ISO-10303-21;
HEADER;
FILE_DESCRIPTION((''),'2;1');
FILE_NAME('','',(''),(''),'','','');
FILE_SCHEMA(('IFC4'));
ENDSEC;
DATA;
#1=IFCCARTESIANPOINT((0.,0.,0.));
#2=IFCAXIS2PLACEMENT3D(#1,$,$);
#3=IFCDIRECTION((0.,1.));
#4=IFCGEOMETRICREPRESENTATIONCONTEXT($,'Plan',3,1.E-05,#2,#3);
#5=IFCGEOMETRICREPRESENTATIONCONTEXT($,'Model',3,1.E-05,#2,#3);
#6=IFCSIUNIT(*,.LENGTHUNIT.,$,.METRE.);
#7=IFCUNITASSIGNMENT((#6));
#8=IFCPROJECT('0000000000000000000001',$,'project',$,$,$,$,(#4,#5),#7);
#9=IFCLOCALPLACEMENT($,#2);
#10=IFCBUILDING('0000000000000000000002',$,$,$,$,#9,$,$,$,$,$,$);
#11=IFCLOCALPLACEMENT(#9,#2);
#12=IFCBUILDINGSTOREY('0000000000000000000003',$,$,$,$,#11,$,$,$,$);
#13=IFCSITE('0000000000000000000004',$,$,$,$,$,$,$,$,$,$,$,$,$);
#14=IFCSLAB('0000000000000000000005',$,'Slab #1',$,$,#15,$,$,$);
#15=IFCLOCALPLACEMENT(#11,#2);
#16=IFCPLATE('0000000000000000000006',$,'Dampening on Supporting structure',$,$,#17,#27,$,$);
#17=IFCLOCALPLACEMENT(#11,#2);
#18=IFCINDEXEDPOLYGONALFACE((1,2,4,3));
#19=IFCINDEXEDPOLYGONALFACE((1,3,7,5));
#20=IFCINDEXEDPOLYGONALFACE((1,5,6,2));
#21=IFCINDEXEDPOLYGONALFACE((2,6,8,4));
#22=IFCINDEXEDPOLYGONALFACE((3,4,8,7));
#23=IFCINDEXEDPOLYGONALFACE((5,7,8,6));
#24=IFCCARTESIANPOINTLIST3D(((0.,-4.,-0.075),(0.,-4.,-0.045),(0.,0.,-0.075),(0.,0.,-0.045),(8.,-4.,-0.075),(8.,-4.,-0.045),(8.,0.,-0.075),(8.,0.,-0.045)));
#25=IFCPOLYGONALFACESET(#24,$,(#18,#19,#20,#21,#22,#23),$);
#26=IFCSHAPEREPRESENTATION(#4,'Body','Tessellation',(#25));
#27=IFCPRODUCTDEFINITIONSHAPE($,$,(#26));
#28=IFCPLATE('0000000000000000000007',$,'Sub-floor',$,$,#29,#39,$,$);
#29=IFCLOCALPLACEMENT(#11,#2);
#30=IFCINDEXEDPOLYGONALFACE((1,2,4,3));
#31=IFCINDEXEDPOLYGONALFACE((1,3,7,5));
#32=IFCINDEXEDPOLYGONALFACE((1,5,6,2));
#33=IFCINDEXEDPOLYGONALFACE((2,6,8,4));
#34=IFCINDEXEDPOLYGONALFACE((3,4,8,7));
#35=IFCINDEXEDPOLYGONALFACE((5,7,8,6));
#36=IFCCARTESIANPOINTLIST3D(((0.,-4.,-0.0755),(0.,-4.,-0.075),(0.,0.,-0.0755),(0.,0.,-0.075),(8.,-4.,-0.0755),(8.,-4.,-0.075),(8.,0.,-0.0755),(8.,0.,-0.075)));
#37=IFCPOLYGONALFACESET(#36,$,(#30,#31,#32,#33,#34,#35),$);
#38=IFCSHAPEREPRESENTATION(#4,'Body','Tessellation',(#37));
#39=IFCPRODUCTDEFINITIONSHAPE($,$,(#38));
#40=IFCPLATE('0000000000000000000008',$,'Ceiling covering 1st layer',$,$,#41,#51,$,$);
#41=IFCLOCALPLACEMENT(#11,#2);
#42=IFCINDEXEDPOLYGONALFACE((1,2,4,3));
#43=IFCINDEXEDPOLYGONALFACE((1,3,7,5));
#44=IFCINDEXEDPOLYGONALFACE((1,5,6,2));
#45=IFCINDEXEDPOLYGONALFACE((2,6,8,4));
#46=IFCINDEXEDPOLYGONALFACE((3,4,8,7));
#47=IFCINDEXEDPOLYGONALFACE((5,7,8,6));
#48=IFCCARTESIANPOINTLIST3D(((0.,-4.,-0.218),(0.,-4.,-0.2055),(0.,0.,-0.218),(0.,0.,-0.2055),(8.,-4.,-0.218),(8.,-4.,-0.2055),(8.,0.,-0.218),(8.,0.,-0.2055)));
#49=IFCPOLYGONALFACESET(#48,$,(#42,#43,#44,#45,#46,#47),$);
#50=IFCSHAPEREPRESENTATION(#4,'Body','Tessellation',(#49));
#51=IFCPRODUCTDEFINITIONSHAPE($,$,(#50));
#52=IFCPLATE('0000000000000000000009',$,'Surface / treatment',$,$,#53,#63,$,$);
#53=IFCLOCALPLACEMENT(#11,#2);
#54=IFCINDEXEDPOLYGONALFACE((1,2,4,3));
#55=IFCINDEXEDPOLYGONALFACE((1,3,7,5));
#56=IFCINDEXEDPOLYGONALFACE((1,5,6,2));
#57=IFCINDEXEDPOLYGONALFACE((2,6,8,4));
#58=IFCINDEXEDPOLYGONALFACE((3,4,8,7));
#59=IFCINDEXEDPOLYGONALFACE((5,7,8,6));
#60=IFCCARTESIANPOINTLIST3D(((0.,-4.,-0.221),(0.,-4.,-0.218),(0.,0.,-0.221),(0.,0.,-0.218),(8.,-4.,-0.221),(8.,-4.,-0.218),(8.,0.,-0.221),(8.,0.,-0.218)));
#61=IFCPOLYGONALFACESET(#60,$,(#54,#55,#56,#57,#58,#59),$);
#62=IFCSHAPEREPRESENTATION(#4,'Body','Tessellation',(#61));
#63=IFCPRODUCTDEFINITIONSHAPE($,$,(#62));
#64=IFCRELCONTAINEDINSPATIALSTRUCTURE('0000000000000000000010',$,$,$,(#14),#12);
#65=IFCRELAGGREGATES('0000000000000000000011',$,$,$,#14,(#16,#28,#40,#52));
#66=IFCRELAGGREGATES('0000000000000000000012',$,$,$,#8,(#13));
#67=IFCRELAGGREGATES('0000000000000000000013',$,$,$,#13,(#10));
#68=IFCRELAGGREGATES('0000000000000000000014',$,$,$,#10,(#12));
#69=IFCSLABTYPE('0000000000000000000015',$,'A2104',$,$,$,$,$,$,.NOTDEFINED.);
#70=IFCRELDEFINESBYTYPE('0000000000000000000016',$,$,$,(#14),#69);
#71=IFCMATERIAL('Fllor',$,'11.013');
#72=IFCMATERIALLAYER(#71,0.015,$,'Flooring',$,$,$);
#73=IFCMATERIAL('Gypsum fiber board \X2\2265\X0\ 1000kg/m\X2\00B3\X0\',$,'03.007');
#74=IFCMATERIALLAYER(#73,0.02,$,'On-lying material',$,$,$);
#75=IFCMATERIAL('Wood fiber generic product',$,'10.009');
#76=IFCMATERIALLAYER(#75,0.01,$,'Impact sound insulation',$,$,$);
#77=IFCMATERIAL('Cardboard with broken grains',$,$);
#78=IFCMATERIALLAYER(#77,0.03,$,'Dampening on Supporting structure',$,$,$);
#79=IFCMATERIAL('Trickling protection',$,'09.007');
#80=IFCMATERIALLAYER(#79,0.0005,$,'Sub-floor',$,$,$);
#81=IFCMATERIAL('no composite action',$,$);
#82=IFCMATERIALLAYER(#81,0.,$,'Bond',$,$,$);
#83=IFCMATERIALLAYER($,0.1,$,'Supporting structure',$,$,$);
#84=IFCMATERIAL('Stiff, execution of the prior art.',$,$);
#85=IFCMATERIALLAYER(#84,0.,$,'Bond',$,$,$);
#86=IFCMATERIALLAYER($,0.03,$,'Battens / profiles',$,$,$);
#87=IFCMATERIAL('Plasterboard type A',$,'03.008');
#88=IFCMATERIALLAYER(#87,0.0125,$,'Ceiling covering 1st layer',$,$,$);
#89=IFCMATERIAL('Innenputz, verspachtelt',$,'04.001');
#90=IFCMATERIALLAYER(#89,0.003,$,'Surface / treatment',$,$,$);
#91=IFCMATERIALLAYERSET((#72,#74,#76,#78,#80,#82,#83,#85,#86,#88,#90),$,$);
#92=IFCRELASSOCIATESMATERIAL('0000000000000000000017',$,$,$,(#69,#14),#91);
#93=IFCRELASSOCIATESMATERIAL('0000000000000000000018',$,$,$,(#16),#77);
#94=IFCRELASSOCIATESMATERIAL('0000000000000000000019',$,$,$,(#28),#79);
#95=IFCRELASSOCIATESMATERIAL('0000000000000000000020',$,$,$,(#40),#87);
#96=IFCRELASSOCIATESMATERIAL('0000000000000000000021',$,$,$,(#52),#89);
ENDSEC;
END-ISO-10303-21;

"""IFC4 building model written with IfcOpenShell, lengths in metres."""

from ifc_helpers import new_model, si_unit, direction, frame, frame_2d, origin, place, context, project, spatial, rectangle, extrude, material, layer, layer_set, type_object, element, aggregate, save


model = new_model("IFC4")

# Units and contexts
plan_context = context("Plan", 3, precision=1e-05, world=origin(), true_north=direction((0.0, 1.0)))
model_context = context("Model", 3, precision=1e-05, world=origin(), true_north=direction((0.0, 1.0)))
ifc_project = project(units=[si_unit("LENGTHUNIT", "METRE")], contexts=[plan_context, model_context])

# Site, building, storey
site = spatial("IfcSite", under=ifc_project)
building_placement = place(None, origin())
building = spatial("IfcBuilding", under=site, at=building_placement)
storey_placement = place(building_placement, origin())
storey = spatial("IfcBuildingStorey", under=building, at=storey_placement)

# Slab, plates
ifc_material_1 = material(Name="Fllor", Category="11.013")
ifc_layer_1 = layer(ifc_material_1, 0.015, Name="Flooring")
ifc_material_2 = material(Name="Gypsum fiber board ≥ 1000kg/m³", Category="03.007")
ifc_layer_2 = layer(ifc_material_2, 0.02, Name="On-lying material")
ifc_material_3 = material(Name="Wood fiber generic product", Category="10.009")
ifc_layer_3 = layer(ifc_material_3, 0.01, Name="Impact sound insulation")
ifc_material_4 = material(Name="Cardboard with broken grains")
ifc_layer_4 = layer(ifc_material_4, 0.03, Name="Dampening on Supporting structure")
ifc_material_5 = material(Name="Trickling protection", Category="09.007")
ifc_layer_5 = layer(ifc_material_5, 0.0005, Name="Sub-floor")
ifc_material_6 = material(Name="no composite action")
ifc_layer_6 = layer(ifc_material_6, 0.0, Name="Bond")
ifc_layer_7 = layer(None, 0.1, Name="Supporting structure")
ifc_material_7 = material(Name="Stiff, execution of the prior art.")
ifc_layer_8 = layer(ifc_material_7, 0.0, Name="Bond")
ifc_layer_9 = layer(None, 0.03, Name="Battens / profiles")
ifc_material_8 = material(Name="Plasterboard type A", Category="03.008")
ifc_layer_10 = layer(ifc_material_8, 0.0125, Name="Ceiling covering 1st layer")
ifc_material_9 = material(Name="Innenputz, verspachtelt", Category="04.001")
ifc_layer_11 = layer(ifc_material_9, 0.003, Name="Surface / treatment")
ifc_layer_set = layer_set([ifc_layer_1, ifc_layer_2, ifc_layer_3, ifc_layer_4, ifc_layer_5, ifc_layer_6, ifc_layer_7, ifc_layer_8, ifc_layer_9, ifc_layer_10, ifc_layer_11])
slab_type = type_object("IfcSlabType", Name="A2104", PredefinedType="NOTDEFINED", material=ifc_layer_set)
slab_placement = place(None, frame((0.0, 0.0, 0.0), z_axis=(0.0, 0.0, -1.0), x_axis=(1.0, 0.0, 0.0)))
slab = element("IfcSlab", 1, at=slab_placement, inside=storey, type_object=slab_type, material=ifc_layer_set, Name="Slab #1")
plate_1_placement = place(slab_placement, origin())
plate_1 = element("IfcPlate", 2, at=plate_1_placement, material=ifc_material_4, Name="Dampening on Supporting structure", context=plan_context, shape_type="SweptSolid", body=[
    extrude(rectangle(XDim=8.0, YDim=4.0, at=frame_2d((4.0, 2.0), x_axis=(1.0, 0.0))), frame((0.0, 0.0, 0.045), z_axis=(0.0, 0.0, 1.0), x_axis=(1.0, 0.0, 0.0)), (0.0, 0.0, 1.0), 0.03),
])
plate_2_placement = place(slab_placement, origin())
plate_2 = element("IfcPlate", 3, at=plate_2_placement, material=ifc_material_5, Name="Sub-floor", context=plan_context, shape_type="SweptSolid", body=[
    extrude(rectangle(XDim=8.0, YDim=4.0, at=frame_2d((4.0, 2.0), x_axis=(1.0, 0.0))), frame((0.0, 0.0, 0.075), z_axis=(0.0, 0.0, 1.0), x_axis=(1.0, 0.0, 0.0)), (0.0, 0.0, 1.0), 0.0005),
])
plate_3_placement = place(slab_placement, origin())
plate_3 = element("IfcPlate", 4, at=plate_3_placement, material=ifc_material_8, Name="Ceiling covering 1st layer", context=plan_context, shape_type="SweptSolid", body=[
    extrude(rectangle(XDim=8.0, YDim=4.0, at=frame_2d((4.0, 2.0), x_axis=(1.0, 0.0))), frame((0.0, 0.0, 0.2055), z_axis=(0.0, 0.0, 1.0), x_axis=(1.0, 0.0, 0.0)), (0.0, 0.0, 1.0), 0.0125),
])
plate_4_placement = place(slab_placement, origin())
plate_4 = element("IfcPlate", 5, at=plate_4_placement, material=ifc_material_9, Name="Surface / treatment", context=plan_context, shape_type="SweptSolid", body=[
    extrude(rectangle(XDim=8.0, YDim=4.0, at=frame_2d((4.0, 2.0), x_axis=(1.0, 0.0))), frame((0.0, 0.0, 0.218), z_axis=(0.0, 0.0, 1.0), x_axis=(1.0, 0.0, 0.0)), (0.0, 0.0, 1.0), 0.003),
])
aggregate(slab, [plate_1, plate_2, plate_3, plate_4])

save(model, "model.ifc")
